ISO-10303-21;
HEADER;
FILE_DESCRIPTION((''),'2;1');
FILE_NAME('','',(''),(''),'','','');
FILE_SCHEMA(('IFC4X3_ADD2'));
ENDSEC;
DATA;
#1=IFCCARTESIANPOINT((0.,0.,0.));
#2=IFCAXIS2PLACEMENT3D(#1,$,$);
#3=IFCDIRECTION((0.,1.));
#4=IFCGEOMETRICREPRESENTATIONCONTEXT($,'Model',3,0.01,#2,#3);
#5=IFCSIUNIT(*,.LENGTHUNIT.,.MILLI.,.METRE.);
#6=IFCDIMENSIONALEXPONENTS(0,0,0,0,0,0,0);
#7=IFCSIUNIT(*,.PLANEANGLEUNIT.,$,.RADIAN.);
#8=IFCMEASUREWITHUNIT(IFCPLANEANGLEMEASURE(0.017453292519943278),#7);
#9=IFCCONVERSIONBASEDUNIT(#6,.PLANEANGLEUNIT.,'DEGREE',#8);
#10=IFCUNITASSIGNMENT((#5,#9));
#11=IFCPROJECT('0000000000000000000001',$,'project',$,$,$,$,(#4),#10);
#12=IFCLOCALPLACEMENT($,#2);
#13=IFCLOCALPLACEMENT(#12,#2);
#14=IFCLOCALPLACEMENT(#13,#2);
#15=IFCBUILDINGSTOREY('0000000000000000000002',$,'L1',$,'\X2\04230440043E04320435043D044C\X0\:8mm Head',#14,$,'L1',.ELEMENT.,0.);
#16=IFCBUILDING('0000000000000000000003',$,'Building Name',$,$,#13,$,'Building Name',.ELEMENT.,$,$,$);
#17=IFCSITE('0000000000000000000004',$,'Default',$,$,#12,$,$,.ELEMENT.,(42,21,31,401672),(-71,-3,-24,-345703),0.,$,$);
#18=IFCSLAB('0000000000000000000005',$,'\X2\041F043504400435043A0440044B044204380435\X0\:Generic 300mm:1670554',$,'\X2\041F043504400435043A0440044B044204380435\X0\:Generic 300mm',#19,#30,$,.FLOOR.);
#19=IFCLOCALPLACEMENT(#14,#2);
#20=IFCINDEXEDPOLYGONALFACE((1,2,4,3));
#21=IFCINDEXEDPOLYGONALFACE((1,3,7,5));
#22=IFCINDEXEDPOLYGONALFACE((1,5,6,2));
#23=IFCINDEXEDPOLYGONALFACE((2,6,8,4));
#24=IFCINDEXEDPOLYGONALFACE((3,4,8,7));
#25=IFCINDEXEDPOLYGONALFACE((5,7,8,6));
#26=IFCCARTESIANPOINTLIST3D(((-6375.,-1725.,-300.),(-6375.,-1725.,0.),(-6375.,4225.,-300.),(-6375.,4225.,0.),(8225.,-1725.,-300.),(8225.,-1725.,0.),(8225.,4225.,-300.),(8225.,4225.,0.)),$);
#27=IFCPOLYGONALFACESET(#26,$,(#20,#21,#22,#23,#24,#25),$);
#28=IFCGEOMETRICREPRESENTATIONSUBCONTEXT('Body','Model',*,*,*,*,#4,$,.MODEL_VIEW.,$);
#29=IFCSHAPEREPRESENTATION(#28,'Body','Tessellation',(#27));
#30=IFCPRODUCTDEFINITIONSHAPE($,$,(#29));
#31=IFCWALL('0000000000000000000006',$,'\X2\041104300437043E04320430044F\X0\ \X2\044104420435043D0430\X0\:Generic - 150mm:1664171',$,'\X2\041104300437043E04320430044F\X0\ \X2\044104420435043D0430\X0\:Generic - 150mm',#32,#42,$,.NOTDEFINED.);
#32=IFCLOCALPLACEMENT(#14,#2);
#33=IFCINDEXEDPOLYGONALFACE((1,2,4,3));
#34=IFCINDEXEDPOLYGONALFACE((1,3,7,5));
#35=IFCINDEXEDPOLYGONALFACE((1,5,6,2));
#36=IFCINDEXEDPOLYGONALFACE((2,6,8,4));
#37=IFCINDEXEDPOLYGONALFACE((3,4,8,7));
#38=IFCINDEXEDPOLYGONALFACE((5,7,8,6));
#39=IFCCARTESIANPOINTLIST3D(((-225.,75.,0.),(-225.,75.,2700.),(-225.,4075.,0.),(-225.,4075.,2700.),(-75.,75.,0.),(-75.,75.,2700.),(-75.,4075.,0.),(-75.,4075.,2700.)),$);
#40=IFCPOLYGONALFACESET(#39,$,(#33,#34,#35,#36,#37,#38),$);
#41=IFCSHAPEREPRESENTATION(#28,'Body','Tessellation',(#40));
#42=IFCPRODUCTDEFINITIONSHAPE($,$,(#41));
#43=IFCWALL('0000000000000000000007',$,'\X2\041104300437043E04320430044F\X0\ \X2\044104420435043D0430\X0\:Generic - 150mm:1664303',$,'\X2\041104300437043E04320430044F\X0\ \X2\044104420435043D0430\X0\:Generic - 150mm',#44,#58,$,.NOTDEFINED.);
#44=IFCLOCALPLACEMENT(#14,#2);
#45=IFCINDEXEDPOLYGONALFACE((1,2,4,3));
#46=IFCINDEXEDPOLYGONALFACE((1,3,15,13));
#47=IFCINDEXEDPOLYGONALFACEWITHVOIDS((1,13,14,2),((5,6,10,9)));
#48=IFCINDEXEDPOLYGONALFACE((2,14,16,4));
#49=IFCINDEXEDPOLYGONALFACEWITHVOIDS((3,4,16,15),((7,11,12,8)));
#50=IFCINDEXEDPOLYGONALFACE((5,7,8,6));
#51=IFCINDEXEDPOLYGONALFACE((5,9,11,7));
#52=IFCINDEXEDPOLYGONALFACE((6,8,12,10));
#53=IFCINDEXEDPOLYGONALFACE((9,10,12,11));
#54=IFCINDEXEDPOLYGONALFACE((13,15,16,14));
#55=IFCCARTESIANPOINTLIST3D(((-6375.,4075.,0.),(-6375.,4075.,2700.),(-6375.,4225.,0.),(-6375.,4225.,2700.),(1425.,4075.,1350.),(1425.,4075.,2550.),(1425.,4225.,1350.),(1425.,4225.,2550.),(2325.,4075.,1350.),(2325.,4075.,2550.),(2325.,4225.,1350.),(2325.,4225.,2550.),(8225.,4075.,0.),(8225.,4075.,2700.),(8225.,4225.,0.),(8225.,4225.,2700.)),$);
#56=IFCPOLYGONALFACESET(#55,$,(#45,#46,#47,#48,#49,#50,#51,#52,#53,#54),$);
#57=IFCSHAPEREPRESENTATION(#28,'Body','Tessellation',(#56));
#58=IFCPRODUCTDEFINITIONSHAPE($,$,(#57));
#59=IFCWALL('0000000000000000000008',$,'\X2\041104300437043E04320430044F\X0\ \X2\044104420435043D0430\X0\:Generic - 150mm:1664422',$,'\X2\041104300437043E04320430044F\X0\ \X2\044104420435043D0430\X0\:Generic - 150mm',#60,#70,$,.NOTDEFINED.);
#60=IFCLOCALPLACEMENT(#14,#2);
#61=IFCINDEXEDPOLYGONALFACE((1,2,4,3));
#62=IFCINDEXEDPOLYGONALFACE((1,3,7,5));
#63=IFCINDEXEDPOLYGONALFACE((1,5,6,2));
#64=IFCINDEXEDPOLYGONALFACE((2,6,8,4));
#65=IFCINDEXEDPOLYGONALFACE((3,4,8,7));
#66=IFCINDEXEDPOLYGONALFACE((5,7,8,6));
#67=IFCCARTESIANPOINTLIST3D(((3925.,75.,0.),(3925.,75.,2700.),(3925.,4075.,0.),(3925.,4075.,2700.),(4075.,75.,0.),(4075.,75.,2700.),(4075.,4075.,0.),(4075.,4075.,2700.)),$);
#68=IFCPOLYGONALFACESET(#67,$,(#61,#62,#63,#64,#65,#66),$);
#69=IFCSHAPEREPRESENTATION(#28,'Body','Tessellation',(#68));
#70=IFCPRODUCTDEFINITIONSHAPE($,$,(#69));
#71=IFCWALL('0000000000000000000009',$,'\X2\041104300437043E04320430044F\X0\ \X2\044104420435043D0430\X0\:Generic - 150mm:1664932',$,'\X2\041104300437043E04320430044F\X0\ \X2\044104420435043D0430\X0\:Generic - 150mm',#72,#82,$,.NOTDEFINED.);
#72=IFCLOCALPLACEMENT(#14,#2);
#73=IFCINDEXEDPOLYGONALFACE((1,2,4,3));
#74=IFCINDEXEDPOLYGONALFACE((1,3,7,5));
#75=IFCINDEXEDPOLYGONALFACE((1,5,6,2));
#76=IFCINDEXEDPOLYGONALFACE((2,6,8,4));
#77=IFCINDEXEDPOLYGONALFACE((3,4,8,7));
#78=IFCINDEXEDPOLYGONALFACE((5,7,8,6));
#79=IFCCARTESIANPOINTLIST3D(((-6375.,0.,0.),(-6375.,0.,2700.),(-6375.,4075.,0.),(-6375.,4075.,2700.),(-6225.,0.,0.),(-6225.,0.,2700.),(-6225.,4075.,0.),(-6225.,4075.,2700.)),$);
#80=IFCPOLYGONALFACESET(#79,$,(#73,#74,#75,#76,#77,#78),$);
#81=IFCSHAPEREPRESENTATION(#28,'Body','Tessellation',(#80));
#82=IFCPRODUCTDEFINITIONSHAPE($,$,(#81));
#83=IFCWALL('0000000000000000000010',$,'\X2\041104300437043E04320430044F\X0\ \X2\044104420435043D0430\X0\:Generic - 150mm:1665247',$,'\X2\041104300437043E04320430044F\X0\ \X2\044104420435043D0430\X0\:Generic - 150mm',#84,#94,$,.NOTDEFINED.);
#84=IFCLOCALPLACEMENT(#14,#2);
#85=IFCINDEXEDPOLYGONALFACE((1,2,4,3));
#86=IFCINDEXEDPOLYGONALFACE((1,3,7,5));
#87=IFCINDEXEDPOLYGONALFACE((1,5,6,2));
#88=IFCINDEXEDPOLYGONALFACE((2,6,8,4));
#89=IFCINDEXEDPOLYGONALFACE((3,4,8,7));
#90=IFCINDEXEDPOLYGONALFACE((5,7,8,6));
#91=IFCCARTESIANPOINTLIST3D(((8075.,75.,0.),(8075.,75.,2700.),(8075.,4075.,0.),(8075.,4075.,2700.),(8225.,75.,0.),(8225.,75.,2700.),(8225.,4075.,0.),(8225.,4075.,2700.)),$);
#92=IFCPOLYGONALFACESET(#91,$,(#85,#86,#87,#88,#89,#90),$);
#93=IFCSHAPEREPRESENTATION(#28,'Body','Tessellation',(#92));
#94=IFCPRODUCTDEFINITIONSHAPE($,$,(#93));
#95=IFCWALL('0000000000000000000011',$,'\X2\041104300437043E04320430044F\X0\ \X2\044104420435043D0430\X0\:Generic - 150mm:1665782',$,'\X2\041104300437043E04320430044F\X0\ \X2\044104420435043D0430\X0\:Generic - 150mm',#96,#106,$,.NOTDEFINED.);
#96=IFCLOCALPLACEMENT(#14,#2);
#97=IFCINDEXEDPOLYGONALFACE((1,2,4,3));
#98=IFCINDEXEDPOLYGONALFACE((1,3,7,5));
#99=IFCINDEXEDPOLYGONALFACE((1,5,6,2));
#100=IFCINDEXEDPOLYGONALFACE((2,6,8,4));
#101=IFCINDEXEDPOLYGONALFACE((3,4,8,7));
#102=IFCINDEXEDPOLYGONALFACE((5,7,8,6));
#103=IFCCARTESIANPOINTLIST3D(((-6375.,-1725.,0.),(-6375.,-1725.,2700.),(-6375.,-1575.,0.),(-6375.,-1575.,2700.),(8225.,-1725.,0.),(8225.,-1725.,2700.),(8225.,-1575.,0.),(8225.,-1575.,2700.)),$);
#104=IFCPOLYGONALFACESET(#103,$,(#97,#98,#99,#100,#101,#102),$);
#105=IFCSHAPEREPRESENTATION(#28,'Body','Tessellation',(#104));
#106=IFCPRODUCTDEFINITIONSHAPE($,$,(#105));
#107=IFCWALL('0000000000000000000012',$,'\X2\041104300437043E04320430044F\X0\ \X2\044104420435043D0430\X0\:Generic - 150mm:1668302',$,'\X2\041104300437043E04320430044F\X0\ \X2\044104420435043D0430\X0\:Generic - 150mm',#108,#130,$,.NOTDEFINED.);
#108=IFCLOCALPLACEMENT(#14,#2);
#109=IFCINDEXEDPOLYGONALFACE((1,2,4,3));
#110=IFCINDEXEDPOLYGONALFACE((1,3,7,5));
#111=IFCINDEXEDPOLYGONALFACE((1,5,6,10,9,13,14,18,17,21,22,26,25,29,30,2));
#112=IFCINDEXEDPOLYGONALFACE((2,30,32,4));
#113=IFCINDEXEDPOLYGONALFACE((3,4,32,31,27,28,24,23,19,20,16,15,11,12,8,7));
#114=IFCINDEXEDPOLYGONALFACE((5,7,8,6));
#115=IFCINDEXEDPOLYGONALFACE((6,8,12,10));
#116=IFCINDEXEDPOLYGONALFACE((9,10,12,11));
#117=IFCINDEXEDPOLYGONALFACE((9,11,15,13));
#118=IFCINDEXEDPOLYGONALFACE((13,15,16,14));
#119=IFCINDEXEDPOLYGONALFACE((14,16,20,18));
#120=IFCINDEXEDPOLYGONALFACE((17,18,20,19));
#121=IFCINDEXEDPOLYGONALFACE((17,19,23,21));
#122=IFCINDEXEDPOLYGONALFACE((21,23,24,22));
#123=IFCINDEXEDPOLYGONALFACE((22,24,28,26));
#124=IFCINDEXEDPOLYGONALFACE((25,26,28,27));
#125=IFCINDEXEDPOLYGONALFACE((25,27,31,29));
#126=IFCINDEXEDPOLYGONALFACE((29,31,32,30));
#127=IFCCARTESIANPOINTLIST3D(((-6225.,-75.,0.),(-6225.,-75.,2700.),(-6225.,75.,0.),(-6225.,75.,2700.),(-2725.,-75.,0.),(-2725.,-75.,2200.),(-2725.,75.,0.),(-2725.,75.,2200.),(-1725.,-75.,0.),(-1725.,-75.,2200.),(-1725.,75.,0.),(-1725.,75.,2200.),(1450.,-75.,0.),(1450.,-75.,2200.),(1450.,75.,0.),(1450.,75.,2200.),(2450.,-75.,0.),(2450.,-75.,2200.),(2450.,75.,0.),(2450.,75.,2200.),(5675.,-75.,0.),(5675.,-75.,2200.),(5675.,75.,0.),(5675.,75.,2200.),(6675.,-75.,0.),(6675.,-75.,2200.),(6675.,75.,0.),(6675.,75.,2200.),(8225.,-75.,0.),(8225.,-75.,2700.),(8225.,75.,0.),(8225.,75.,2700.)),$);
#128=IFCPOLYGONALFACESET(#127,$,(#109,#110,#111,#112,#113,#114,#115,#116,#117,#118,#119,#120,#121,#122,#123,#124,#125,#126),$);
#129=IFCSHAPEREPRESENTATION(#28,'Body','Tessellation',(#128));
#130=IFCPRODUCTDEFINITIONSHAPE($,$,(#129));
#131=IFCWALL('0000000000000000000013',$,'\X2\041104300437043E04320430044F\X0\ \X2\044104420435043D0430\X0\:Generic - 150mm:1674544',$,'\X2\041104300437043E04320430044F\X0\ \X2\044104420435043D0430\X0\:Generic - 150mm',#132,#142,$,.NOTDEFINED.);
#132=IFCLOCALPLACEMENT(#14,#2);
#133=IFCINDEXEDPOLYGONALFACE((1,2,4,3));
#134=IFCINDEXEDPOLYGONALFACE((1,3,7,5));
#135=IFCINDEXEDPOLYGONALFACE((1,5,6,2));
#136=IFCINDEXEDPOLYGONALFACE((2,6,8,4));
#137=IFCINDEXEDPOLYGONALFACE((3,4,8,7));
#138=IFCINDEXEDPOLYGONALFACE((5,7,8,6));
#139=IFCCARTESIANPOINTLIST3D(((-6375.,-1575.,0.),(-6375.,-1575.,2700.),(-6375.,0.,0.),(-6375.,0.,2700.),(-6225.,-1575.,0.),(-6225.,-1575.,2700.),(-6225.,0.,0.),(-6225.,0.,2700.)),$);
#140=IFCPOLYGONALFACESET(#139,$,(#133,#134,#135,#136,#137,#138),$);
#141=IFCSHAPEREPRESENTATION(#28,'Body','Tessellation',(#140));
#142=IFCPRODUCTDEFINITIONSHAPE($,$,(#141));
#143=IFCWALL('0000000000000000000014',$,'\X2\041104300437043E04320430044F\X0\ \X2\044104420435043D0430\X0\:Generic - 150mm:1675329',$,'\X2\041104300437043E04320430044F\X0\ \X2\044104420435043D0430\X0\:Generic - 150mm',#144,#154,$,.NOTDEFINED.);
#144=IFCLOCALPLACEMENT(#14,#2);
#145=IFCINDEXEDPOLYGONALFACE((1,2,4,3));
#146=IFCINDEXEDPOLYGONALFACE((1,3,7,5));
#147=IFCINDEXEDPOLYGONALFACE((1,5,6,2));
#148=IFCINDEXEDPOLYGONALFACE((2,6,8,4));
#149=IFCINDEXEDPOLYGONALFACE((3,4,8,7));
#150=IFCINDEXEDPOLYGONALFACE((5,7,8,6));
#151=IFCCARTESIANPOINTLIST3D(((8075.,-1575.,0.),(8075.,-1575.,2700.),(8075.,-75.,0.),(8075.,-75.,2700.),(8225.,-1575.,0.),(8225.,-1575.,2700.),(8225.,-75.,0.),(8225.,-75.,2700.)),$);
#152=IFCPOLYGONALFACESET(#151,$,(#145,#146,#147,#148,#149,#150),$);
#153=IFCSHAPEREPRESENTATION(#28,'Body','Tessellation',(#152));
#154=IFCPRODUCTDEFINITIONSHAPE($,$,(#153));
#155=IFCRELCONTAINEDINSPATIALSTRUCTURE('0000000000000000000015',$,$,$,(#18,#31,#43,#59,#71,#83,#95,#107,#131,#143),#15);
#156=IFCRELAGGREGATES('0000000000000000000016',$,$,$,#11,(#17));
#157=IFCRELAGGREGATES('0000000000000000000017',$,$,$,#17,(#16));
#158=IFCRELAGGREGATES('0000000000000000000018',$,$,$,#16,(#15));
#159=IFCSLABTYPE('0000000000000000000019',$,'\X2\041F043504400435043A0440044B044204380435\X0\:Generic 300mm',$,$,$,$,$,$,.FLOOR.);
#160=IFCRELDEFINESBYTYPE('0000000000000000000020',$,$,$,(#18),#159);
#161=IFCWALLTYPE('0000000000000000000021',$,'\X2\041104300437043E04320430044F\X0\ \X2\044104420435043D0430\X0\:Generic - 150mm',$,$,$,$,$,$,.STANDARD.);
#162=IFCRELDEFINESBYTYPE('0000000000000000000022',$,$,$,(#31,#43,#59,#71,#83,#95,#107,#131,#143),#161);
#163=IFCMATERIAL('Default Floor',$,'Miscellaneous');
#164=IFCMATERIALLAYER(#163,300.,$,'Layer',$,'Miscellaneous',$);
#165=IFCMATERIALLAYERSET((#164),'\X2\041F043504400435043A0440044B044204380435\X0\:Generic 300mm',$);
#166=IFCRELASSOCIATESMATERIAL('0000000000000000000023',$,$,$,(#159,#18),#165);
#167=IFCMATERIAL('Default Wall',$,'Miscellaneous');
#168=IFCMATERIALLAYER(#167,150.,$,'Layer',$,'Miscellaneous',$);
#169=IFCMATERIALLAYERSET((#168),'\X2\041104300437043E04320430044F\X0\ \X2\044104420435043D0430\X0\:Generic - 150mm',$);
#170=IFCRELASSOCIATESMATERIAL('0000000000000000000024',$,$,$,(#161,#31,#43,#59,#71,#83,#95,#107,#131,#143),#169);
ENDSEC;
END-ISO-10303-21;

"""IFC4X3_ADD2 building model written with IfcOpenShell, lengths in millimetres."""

from ifc_helpers import new_model, entity, si_unit, converted_unit, direction, frame, frame_2d, origin, origin_2d_with_axis, place, context, subcontext, project, spatial, rectangle, extrude, material, layer, layer_set, layer_usage, type_object, element, save


model = new_model("IFC4X3_ADD2")

# Units and contexts
model_context = context("Model", 3, precision=0.01, world=origin(), true_north=direction((0.0, 1.0)))
body_context = subcontext(model_context, "Body", "Model", "MODEL_VIEW")
ifc_project = project(units=[si_unit("LENGTHUNIT", "METRE", prefix="MILLI"), converted_unit("PLANEANGLEUNIT", "DEGREE", entity("IfcPlaneAngleMeasure", 0.017453292519943278), si_unit("PLANEANGLEUNIT", "RADIAN"), dimensions=[0, 0, 0, 0, 0, 0, 0])], contexts=[model_context])

# Site, building, storey
site_placement = place(None, origin())
site = spatial("IfcSite", under=ifc_project, at=site_placement, Name="Default", CompositionType="ELEMENT", RefLatitude=(42, 21, 31, 401672), RefLongitude=(-71, -3, -24, -345703), RefElevation=0.0)
building_placement = place(site_placement, origin())
building = spatial("IfcBuilding", under=site, at=building_placement, Name="Building Name", LongName="Building Name", CompositionType="ELEMENT")
storey_placement = place(building_placement, origin())
storey = spatial("IfcBuildingStorey", under=building, at=storey_placement, Name="L1", ObjectType="Уровень:8mm Head", LongName="L1", CompositionType="ELEMENT", Elevation=0.0)

# Slab
ifc_material_1 = material(Name="Default Floor", Category="Miscellaneous")
ifc_layer_1 = layer(ifc_material_1, 300.0, Name="Layer", Category="Miscellaneous")
ifc_layer_set_1 = layer_set([ifc_layer_1], Name="Перекрытие:Generic 300mm")
ifc_layer_usage = layer_usage(ifc_layer_set_1, "AXIS3", "POSITIVE", 0.0)
slab_type = type_object("IfcSlabType", Name="Перекрытие:Generic 300mm", PredefinedType="FLOOR", material=ifc_layer_set_1)
slab_placement = place(storey_placement, origin())
element("IfcSlab", 1, at=slab_placement, inside=storey, type_object=slab_type, material=ifc_layer_usage, Name="Перекрытие:Generic 300mm:1670554", ObjectType="Перекрытие:Generic 300mm", PredefinedType="FLOOR", context=body_context, shape_type="SweptSolid", body=[
    extrude(rectangle(XDim=5950.0, YDim=14600.0, at=origin_2d_with_axis()), frame((925.0, 1250.0, 0.0), z_axis=(0.0, 0.0, -1.0), x_axis=(0.0, 1.0, 0.0)), (0.0, 0.0, 1.0), 300.0),
])

# Wall
ifc_material_2 = material(Name="Default Wall", Category="Miscellaneous")
ifc_layer_2 = layer(ifc_material_2, 150.0, Name="Layer", Category="Miscellaneous")
ifc_layer_set_2 = layer_set([ifc_layer_2], Name="Базовая стена:Generic - 150mm")
wall_type = type_object("IfcWallType", Name="Базовая стена:Generic - 150mm", PredefinedType="STANDARD", material=ifc_layer_set_2)
wall_1_placement = place(storey_placement, frame((-150.0, 75.0, 0.0), z_axis=(0.0, 0.0, 1.0), x_axis=(0.0, 1.0, 0.0)))
element("IfcWall", 2, at=wall_1_placement, inside=storey, type_object=wall_type, material=ifc_layer_set_2, Name="Базовая стена:Generic - 150mm:1664171", ObjectType="Базовая стена:Generic - 150mm", PredefinedType="NOTDEFINED", context=body_context, shape_type="SweptSolid", body=[
    extrude(rectangle(XDim=4000.0, YDim=150.0, at=frame_2d((2000.0, 0.0), x_axis=(-1.0, 0.0))), origin(), (0.0, 0.0, 1.0), 2700.0),
])

# Wall, opening
wall_2_placement = place(storey_placement, frame((-6375.0, 4150.0, 0.0)))
wall_2 = element("IfcWall", 3, at=wall_2_placement, inside=storey, type_object=wall_type, material=ifc_layer_set_2, Name="Базовая стена:Generic - 150mm:1664303", ObjectType="Базовая стена:Generic - 150mm", PredefinedType="NOTDEFINED", context=body_context, shape_type="SweptSolid", body=[
    extrude(rectangle(XDim=14600.0, YDim=150.0, at=frame_2d((7300.0, 0.0), x_axis=(-1.0, 0.0))), origin(), (0.0, 0.0, 1.0), 2700.0),
])
opening_1_placement = place(wall_2_placement, frame((7800.0, -75.0, 1350.0)))
element("IfcOpeningElement", 4, at=opening_1_placement, cuts=wall_2, PredefinedType="OPENING", context=body_context, shape_type="SweptSolid", body=[
    extrude(rectangle(XDim=1200.0, YDim=900.0, at=frame_2d((600.0, 450.0), x_axis=(-1.0, 0.0))), frame((0.0, 0.0, 0.0), z_axis=(0.0, 1.0, 0.0), x_axis=(0.0, 0.0, 1.0)), (0.0, 0.0, 1.0), 150.0),
])

# Walls
wall_3_placement = place(storey_placement, frame((4000.0, 4075.0, 0.0), z_axis=(0.0, 0.0, 1.0), x_axis=(0.0, -1.0, 0.0)))
element("IfcWall", 5, at=wall_3_placement, inside=storey, type_object=wall_type, material=ifc_layer_set_2, Name="Базовая стена:Generic - 150mm:1664422", ObjectType="Базовая стена:Generic - 150mm", PredefinedType="NOTDEFINED", context=body_context, shape_type="SweptSolid", body=[
    extrude(rectangle(XDim=4000.0, YDim=150.0, at=frame_2d((2000.0, 0.0), x_axis=(-1.0, 0.0))), origin(), (0.0, 0.0, 1.0), 2700.0),
])
wall_4_placement = place(storey_placement, frame((-6300.0, 4075.0, 0.0), z_axis=(0.0, 0.0, 1.0), x_axis=(0.0, -1.0, 0.0)))
element("IfcWall", 6, at=wall_4_placement, inside=storey, type_object=wall_type, material=ifc_layer_set_2, Name="Базовая стена:Generic - 150mm:1664932", ObjectType="Базовая стена:Generic - 150mm", PredefinedType="NOTDEFINED", context=body_context, shape_type="SweptSolid", body=[
    extrude(rectangle(XDim=4075.0, YDim=150.0, at=frame_2d((2037.5, 0.0), x_axis=(-1.0, 0.0))), origin(), (0.0, 0.0, 1.0), 2700.0),
])
wall_5_placement = place(storey_placement, frame((8150.0, 4075.0, 0.0), z_axis=(0.0, 0.0, 1.0), x_axis=(0.0, -1.0, 0.0)))
element("IfcWall", 7, at=wall_5_placement, inside=storey, type_object=wall_type, material=ifc_layer_set_2, Name="Базовая стена:Generic - 150mm:1665247", ObjectType="Базовая стена:Generic - 150mm", PredefinedType="NOTDEFINED", context=body_context, shape_type="SweptSolid", body=[
    extrude(rectangle(XDim=4000.0, YDim=150.0, at=frame_2d((2000.0, 0.0), x_axis=(-1.0, 0.0))), origin(), (0.0, 0.0, 1.0), 2700.0),
])
wall_6_placement = place(storey_placement, frame((8225.0, -1650.0, 0.0), z_axis=(0.0, 0.0, 1.0), x_axis=(-1.0, 0.0, 0.0)))
element("IfcWall", 8, at=wall_6_placement, inside=storey, type_object=wall_type, material=ifc_layer_set_2, Name="Базовая стена:Generic - 150mm:1665782", ObjectType="Базовая стена:Generic - 150mm", PredefinedType="NOTDEFINED", context=body_context, shape_type="SweptSolid", body=[
    extrude(rectangle(XDim=14600.0, YDim=150.0, at=frame_2d((7300.0, 0.0), x_axis=(-1.0, 0.0))), origin(), (0.0, 0.0, 1.0), 2700.0),
])

# Wall, openings
wall_7_placement = place(storey_placement, frame((8225.0, 0.0, 0.0), z_axis=(0.0, 0.0, 1.0), x_axis=(-1.0, 0.0, 0.0)))
wall_7 = element("IfcWall", 9, at=wall_7_placement, inside=storey, type_object=wall_type, material=ifc_layer_set_2, Name="Базовая стена:Generic - 150mm:1668302", ObjectType="Базовая стена:Generic - 150mm", PredefinedType="NOTDEFINED", context=body_context, shape_type="SweptSolid", body=[
    extrude(rectangle(XDim=14450.0, YDim=150.0, at=frame_2d((7225.0, 0.0), x_axis=(-1.0, 0.0))), origin(), (0.0, 0.0, 1.0), 2700.0),
])
opening_2_placement = place(wall_7_placement, frame((6775.0, 75.0, 0.0)))
element("IfcOpeningElement", 10, at=opening_2_placement, cuts=wall_7, PredefinedType="OPENING", context=body_context, shape_type="SweptSolid", body=[
    extrude(rectangle(XDim=2200.0, YDim=1000.0, at=frame_2d((1100.0, 500.0), x_axis=(1.0, 0.0))), frame((0.0, 0.0, 0.0), z_axis=(0.0, -1.0, 0.0), x_axis=(0.0, 0.0, 1.0)), (0.0, 0.0, 1.0), 150.0),
])
opening_3_placement = place(wall_7_placement, frame((8225.0, 0.0, 0.0), z_axis=(0.0, 0.0, 1.0), x_axis=(-1.0, 0.0, 0.0)))
element("IfcOpeningElement", 11, at=opening_3_placement, cuts=wall_7, PredefinedType="OPENING", context=body_context, shape_type="SweptSolid", body=[
    extrude(rectangle(XDim=2200.0, YDim=1000.0, at=frame_2d((0.0, 0.0), x_axis=(1.0, 0.0))), frame((1950.0, 1449.0, 1100.0), z_axis=(0.0, -1.0, 0.0), x_axis=(0.0, 0.0, 1.0)), (0.0, 0.0, 1.0), 3048.0),
])
opening_4_placement = place(wall_7_placement, frame((10950.0, 75.0, 0.0)))
element("IfcOpeningElement", 12, at=opening_4_placement, cuts=wall_7, PredefinedType="OPENING", context=body_context, shape_type="SweptSolid", body=[
    extrude(rectangle(XDim=2200.0, YDim=1000.0, at=frame_2d((1100.0, 500.0), x_axis=(1.0, 0.0))), frame((0.0, 0.0, 0.0), z_axis=(0.0, -1.0, 0.0), x_axis=(0.0, 0.0, 1.0)), (0.0, 0.0, 1.0), 150.0),
])
opening_5_placement = place(wall_7_placement, frame((1550.0, -75.0, 0.0)))
element("IfcOpeningElement", 13, at=opening_5_placement, cuts=wall_7, PredefinedType="OPENING", context=body_context, shape_type="SweptSolid", body=[
    extrude(rectangle(XDim=2200.0, YDim=1000.0, at=frame_2d((1100.0, 500.0), x_axis=(1.0, 0.0))), frame((0.0, 0.0, 0.0), z_axis=(0.0, 1.0, 0.0), x_axis=(0.0, 0.0, 1.0)), (0.0, 0.0, 1.0), 150.0),
])

# Walls
wall_8_placement = place(storey_placement, frame((-6300.0, 0.0, 0.0), z_axis=(0.0, 0.0, 1.0), x_axis=(0.0, -1.0, 0.0)))
element("IfcWall", 14, at=wall_8_placement, inside=storey, type_object=wall_type, material=ifc_layer_set_2, Name="Базовая стена:Generic - 150mm:1674544", ObjectType="Базовая стена:Generic - 150mm", PredefinedType="NOTDEFINED", context=body_context, shape_type="SweptSolid", body=[
    extrude(rectangle(XDim=1575.0, YDim=150.0, at=frame_2d((787.5, 0.0), x_axis=(-1.0, 0.0))), origin(), (0.0, 0.0, 1.0), 2700.0),
])
wall_9_placement = place(storey_placement, frame((8150.0, -75.0, 0.0), z_axis=(0.0, 0.0, 1.0), x_axis=(0.0, -1.0, 0.0)))
element("IfcWall", 15, at=wall_9_placement, inside=storey, type_object=wall_type, material=ifc_layer_set_2, Name="Базовая стена:Generic - 150mm:1675329", ObjectType="Базовая стена:Generic - 150mm", PredefinedType="NOTDEFINED", context=body_context, shape_type="SweptSolid", body=[
    extrude(rectangle(XDim=1500.0, YDim=150.0, at=frame_2d((750.0, 0.0), x_axis=(-1.0, 0.0))), origin(), (0.0, 0.0, 1.0), 2700.0),
])

save(model, "model.ifc")
